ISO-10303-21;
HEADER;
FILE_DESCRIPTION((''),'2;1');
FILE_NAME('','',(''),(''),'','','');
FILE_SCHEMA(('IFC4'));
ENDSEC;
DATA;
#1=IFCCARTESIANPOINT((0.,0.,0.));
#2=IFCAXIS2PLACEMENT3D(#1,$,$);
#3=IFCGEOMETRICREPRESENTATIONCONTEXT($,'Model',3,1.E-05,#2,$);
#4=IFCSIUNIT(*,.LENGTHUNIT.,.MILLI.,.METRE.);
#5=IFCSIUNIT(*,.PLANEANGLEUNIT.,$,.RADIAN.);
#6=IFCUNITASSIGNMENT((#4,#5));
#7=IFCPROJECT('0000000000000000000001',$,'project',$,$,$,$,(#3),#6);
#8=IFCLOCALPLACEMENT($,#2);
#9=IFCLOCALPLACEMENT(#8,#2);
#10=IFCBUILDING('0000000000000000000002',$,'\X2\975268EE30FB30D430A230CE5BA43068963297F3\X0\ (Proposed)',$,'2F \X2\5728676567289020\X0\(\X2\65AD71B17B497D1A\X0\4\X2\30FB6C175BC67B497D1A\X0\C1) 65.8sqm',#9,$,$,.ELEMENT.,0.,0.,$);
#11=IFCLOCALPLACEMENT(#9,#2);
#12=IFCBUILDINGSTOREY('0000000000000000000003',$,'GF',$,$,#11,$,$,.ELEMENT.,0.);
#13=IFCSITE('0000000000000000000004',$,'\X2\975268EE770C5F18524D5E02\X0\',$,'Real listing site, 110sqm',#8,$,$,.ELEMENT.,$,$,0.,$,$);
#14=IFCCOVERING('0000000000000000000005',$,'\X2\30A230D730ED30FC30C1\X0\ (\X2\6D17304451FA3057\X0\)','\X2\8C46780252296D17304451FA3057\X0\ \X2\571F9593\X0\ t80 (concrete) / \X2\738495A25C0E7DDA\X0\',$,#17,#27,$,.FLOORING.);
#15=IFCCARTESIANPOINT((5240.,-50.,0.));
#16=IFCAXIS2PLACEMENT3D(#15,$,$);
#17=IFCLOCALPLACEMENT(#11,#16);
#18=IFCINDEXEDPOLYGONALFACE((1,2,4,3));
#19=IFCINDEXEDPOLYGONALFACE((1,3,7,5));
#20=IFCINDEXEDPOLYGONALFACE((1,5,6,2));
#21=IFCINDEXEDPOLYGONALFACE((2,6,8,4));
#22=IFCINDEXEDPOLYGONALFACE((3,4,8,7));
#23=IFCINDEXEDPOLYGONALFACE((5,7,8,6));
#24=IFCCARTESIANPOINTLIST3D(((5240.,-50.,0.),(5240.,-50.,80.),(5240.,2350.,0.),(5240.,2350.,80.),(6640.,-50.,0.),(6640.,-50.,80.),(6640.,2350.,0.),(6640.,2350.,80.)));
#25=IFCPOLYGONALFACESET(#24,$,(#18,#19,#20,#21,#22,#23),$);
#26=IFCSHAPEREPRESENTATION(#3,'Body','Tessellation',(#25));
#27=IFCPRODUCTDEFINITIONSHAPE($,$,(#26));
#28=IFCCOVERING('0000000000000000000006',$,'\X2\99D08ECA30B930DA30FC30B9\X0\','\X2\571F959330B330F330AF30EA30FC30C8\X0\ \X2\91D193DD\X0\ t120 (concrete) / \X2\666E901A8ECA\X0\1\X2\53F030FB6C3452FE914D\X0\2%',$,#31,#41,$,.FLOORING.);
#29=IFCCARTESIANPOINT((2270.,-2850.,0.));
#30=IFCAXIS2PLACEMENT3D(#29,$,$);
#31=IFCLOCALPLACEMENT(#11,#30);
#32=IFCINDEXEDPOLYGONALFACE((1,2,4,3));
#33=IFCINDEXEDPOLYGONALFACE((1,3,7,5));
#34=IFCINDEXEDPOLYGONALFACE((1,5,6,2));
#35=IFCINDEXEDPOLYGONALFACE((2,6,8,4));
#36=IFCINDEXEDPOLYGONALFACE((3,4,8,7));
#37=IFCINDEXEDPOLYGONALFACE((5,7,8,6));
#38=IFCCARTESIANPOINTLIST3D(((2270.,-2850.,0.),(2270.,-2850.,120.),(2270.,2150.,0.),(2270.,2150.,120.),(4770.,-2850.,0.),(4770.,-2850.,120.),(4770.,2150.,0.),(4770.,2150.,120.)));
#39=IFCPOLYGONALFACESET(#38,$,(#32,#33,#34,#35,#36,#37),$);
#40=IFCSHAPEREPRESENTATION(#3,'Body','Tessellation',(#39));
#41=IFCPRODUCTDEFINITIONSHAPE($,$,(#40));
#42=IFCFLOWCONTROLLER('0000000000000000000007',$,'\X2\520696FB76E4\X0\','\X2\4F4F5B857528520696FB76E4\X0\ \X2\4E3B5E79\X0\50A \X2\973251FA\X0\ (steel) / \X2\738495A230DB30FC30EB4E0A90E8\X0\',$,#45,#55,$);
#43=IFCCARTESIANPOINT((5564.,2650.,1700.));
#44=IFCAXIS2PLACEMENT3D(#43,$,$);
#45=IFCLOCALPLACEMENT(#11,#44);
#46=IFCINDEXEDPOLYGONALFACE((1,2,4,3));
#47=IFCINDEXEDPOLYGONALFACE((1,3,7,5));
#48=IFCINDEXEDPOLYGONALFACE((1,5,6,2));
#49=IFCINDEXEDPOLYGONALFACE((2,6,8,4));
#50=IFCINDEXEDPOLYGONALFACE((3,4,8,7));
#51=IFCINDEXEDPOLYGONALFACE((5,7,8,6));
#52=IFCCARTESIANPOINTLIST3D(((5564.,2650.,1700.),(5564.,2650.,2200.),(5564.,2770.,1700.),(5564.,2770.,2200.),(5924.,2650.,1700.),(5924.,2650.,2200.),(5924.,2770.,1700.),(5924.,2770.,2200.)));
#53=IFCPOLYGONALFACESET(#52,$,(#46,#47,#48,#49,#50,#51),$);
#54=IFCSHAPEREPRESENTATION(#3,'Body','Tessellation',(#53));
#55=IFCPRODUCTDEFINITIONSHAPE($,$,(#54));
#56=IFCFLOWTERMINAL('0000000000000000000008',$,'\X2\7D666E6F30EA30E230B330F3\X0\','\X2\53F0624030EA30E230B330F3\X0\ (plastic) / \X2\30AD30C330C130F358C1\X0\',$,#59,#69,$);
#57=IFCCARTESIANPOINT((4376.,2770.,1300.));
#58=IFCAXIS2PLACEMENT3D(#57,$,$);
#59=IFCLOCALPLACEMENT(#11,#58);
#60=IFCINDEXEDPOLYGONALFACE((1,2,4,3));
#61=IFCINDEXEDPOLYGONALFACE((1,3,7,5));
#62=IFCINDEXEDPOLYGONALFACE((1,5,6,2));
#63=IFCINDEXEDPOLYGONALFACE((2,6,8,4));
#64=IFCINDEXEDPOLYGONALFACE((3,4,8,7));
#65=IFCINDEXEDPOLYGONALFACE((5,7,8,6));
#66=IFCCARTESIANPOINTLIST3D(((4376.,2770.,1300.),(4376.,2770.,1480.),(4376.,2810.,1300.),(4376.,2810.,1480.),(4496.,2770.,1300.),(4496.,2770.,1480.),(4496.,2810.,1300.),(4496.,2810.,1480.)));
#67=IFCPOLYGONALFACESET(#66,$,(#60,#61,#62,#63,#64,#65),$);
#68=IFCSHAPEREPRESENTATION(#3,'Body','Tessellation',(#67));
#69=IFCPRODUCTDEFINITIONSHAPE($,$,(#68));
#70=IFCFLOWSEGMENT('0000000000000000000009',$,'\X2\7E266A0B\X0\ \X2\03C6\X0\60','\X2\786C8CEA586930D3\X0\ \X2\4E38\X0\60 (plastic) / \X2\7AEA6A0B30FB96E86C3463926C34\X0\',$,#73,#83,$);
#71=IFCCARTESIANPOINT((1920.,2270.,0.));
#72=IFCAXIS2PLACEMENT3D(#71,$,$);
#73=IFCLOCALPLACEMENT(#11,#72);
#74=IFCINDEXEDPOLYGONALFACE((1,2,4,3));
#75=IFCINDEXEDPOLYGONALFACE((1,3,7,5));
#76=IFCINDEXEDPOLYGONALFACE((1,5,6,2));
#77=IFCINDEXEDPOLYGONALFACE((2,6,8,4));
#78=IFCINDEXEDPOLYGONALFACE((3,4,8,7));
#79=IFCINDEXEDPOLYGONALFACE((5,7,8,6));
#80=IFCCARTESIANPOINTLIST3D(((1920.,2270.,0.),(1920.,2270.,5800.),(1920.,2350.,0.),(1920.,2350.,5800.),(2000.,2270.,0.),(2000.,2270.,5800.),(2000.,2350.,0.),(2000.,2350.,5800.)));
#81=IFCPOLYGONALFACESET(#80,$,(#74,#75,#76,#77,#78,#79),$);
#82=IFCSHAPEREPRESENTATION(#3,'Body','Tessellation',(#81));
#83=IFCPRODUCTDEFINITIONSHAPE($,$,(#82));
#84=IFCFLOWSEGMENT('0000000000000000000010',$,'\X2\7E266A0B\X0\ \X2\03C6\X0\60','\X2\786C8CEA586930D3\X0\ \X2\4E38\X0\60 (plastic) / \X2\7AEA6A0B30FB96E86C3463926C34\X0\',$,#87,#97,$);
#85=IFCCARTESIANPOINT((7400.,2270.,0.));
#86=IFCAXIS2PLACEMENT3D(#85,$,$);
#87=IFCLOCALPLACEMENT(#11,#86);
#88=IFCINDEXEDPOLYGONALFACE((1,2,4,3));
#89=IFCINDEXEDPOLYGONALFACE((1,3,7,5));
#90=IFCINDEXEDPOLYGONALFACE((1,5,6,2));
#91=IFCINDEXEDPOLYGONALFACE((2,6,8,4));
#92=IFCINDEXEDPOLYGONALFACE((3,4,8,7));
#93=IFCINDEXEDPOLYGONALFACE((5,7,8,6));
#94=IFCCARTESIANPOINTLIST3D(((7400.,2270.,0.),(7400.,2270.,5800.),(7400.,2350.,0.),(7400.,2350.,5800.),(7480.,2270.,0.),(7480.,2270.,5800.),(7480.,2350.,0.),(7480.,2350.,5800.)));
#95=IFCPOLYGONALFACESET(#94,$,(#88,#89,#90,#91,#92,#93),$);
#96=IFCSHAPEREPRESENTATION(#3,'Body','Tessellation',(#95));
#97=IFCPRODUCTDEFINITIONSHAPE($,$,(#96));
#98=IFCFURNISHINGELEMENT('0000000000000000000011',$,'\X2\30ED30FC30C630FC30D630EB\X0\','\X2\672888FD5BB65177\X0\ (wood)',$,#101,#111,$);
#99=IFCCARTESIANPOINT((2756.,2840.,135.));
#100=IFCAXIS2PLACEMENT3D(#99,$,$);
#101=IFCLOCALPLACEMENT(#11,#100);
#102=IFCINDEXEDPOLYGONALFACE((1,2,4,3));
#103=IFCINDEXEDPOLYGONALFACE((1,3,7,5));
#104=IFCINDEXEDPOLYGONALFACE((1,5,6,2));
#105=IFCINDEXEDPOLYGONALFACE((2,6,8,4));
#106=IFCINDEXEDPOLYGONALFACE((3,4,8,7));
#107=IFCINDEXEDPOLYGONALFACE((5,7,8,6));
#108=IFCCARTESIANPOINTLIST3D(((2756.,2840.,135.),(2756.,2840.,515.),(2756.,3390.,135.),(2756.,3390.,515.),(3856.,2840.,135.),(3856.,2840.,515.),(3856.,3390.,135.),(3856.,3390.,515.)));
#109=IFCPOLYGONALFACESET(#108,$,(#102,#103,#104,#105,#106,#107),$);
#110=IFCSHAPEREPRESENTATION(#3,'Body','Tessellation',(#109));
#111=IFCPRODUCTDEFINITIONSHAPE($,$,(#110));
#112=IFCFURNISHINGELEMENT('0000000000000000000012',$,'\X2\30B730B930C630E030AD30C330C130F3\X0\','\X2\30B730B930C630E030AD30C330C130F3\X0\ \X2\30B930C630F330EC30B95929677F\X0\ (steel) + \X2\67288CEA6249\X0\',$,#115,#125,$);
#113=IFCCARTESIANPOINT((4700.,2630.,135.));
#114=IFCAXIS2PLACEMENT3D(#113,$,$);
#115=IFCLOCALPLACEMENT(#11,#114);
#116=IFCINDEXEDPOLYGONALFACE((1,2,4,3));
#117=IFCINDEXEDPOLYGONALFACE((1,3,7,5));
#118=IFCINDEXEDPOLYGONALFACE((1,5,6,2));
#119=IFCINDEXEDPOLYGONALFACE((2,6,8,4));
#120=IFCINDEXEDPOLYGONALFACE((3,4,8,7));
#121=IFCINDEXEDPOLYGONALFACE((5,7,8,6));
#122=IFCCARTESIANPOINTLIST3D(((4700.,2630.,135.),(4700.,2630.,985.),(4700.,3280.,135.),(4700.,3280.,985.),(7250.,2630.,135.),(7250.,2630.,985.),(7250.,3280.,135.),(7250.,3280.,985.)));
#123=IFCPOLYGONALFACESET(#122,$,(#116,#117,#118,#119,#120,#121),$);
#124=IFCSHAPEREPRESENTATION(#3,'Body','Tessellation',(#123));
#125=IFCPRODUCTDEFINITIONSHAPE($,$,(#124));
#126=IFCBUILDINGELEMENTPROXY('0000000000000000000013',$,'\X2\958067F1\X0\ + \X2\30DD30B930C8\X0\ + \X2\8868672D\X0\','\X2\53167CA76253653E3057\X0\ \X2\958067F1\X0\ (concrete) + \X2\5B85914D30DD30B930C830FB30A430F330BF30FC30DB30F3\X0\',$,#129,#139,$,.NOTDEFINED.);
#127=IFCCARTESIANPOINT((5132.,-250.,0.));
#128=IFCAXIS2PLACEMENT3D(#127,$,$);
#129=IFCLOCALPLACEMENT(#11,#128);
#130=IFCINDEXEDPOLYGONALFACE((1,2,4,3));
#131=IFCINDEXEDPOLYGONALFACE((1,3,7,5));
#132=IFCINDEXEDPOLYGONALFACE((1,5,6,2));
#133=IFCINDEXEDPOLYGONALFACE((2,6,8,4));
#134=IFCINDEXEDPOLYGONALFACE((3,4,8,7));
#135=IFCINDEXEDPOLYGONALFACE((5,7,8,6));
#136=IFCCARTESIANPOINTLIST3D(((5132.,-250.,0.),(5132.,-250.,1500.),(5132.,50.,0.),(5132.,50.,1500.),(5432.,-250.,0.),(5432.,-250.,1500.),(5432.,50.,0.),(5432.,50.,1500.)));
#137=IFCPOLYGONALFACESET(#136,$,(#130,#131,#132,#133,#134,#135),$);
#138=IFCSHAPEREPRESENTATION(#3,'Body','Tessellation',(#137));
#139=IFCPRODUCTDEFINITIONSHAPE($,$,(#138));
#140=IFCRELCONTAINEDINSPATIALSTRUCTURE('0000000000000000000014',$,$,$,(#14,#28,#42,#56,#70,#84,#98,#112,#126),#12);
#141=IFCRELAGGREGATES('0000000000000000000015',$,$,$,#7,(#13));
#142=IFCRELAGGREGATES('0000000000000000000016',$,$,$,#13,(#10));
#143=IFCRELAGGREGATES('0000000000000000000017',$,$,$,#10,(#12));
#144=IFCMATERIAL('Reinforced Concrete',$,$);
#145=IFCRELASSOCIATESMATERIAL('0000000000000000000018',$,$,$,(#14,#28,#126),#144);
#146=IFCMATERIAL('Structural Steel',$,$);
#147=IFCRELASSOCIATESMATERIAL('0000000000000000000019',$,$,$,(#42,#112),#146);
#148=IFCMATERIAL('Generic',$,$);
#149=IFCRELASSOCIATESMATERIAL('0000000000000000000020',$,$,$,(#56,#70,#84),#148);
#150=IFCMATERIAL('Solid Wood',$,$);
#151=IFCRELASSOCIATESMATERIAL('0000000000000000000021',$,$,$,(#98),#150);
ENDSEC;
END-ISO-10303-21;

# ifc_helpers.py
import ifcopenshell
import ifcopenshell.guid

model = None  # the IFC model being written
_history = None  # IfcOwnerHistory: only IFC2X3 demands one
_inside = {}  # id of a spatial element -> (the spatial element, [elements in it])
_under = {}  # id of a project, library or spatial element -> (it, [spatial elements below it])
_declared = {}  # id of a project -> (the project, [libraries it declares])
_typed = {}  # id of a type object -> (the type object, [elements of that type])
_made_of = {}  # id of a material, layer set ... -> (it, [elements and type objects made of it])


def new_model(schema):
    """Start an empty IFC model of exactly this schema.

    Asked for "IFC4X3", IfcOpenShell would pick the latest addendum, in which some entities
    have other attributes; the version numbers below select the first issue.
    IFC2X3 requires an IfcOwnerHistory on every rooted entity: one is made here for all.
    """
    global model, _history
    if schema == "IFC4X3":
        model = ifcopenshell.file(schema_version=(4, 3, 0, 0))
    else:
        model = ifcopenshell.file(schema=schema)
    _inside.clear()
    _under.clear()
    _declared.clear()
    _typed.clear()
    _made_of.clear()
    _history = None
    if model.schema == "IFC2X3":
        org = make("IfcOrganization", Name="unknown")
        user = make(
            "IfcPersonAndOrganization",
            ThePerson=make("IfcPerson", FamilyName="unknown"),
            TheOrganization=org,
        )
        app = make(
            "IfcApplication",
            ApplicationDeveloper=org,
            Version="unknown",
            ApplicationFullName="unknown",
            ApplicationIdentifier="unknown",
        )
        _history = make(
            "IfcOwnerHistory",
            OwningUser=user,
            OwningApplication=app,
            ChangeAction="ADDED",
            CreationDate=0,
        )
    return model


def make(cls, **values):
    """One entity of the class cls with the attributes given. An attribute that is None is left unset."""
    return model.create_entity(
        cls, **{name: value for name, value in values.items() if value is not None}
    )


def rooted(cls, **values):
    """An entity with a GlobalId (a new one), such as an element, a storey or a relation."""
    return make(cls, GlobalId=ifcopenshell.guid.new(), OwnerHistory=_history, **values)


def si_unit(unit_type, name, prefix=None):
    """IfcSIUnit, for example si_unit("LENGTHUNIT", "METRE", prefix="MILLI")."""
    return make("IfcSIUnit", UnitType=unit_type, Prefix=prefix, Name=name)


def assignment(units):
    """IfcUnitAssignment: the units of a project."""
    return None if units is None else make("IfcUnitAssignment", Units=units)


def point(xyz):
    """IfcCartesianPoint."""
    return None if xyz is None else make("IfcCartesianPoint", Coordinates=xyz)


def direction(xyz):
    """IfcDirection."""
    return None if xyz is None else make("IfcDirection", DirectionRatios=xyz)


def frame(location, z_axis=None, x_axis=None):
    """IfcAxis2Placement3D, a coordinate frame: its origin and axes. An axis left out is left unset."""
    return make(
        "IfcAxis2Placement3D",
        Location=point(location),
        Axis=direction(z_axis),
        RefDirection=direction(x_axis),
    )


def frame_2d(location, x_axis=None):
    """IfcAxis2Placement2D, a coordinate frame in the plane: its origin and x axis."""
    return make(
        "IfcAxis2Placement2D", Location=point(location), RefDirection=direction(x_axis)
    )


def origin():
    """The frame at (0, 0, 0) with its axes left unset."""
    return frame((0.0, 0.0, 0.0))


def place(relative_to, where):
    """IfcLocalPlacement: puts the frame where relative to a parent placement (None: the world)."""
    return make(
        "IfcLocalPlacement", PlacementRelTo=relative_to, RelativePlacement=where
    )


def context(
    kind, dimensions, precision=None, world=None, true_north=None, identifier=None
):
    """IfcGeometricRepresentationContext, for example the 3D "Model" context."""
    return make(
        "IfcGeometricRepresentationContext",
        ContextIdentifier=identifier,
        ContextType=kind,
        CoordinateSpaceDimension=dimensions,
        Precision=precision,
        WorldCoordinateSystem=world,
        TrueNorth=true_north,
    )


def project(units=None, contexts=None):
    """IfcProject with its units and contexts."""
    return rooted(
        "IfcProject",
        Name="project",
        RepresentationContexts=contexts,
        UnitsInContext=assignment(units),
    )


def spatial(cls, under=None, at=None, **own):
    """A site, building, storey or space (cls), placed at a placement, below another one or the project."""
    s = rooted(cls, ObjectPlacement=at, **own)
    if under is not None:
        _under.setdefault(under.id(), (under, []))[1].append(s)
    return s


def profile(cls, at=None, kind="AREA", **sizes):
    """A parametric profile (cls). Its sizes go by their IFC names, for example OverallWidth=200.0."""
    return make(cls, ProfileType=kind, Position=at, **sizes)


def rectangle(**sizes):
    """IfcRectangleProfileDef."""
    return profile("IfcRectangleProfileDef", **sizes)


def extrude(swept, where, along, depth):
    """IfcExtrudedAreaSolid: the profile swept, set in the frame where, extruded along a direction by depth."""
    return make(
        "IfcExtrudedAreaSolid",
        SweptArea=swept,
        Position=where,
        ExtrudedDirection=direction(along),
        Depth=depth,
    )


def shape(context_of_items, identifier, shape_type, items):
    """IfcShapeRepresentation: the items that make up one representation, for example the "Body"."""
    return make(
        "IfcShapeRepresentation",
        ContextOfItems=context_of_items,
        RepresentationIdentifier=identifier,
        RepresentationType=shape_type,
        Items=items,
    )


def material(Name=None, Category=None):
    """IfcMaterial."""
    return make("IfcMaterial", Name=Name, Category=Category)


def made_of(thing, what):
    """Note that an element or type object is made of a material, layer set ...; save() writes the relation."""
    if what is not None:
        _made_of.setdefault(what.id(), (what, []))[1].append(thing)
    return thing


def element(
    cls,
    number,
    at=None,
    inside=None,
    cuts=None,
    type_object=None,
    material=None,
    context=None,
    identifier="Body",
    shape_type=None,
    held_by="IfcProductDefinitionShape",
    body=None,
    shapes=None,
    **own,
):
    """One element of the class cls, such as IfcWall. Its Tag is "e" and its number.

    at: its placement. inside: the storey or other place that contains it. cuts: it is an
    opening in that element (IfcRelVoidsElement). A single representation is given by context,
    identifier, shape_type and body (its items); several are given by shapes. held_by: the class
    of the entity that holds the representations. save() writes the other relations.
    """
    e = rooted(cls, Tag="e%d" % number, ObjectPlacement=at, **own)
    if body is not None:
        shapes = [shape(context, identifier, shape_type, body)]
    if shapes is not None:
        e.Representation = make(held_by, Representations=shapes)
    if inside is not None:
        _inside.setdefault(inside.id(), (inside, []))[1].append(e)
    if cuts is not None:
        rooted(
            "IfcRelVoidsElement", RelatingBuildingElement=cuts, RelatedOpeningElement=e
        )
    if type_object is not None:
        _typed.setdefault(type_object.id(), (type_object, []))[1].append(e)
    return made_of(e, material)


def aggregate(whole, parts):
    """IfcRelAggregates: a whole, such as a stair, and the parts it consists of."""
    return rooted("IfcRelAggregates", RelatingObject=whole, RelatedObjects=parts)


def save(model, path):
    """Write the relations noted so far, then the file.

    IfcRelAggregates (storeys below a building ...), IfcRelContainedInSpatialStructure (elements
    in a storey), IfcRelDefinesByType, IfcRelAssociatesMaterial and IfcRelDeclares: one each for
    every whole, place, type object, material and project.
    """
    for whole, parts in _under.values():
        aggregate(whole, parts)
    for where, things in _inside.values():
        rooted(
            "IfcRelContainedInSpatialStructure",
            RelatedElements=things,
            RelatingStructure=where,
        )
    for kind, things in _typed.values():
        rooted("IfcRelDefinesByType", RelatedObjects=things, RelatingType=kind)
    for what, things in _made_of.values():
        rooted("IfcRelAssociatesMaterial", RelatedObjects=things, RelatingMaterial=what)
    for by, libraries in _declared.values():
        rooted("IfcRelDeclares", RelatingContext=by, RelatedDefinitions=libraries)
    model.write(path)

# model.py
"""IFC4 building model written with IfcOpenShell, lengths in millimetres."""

from ifc_helpers import new_model, si_unit, frame, frame_2d, origin, place, context, project, spatial, rectangle, extrude, material, element, save


model = new_model("IFC4")

# Units and contexts
model_context = context("Model", 3, precision=1e-05, world=origin())
ifc_project = project(units=[si_unit("LENGTHUNIT", "METRE", prefix="MILLI"), si_unit("PLANEANGLEUNIT", "RADIAN")], contexts=[model_context])

# Site, building, storey
site_placement = place(None, origin())
site = spatial("IfcSite", under=ifc_project, at=site_placement, Name="青森県弘前市", ObjectType="Real listing site, 110sqm", CompositionType="ELEMENT", RefElevation=0.0)
building_placement = place(site_placement, origin())
building = spatial("IfcBuilding", under=site, at=building_placement, Name="青森・ピアノ室と防音 (Proposed)", ObjectType="2F 在来木造(断熱等級4・気密等級C1) 65.8sqm", CompositionType="ELEMENT", ElevationOfRefHeight=0.0, ElevationOfTerrain=0.0)
storey_placement = place(building_placement, origin())
storey = spatial("IfcBuildingStorey", under=building, at=storey_placement, Name="GF", CompositionType="ELEMENT", Elevation=0.0)

# Shared definitions
ifc_material_1 = material(Name="Solid Wood")

# Shared definitions
ifc_material_2 = material(Name="Reinforced Concrete")

# Coverings
ifc_material_3 = material(Name="Generic")
covering_1_placement = place(storey_placement, frame((5240.0, -50.0, 0.0)))
element("IfcCovering", 1, at=covering_1_placement, inside=storey, material=ifc_material_2, Name="アプローチ (洗い出し)", Description="豆砂利洗い出し 土間 t80 (concrete) / 玄関導線", PredefinedType="FLOORING", context=model_context, shape_type="SweptSolid", body=[
    extrude(rectangle(XDim=1400.0, YDim=2400.0, at=frame_2d((700.0, 1200.0))), frame((5240.0, -50.0, 0.0)), (0.0, 0.0, 1.0), 80.0),
])
covering_2_placement = place(storey_placement, frame((2270.0, -2850.0, 0.0)))
element("IfcCovering", 2, at=covering_2_placement, inside=storey, material=ifc_material_2, Name="駐車スペース", Description="土間コンクリート 金鏝 t120 (concrete) / 普通車1台・水勾配2%", PredefinedType="FLOORING", context=model_context, shape_type="SweptSolid", body=[
    extrude(rectangle(XDim=2500.0, YDim=5000.0, at=frame_2d((1250.0, 2500.0))), frame((2270.0, -2850.0, 0.0)), (0.0, 0.0, 1.0), 120.0),
])

# Flow controller
ifc_material_4 = material(Name="Structural Steel")
flow_controller_placement = place(storey_placement, frame((5564.0, 2650.0, 1700.0)))
element("IfcFlowController", 3, at=flow_controller_placement, inside=storey, material=ifc_material_4, Name="分電盤", Description="住宅用分電盤 主幹50A 露出 (steel) / 玄関ホール上部", context=model_context, shape_type="SweptSolid", body=[
    extrude(rectangle(XDim=360.0, YDim=120.0, at=frame_2d((180.0, 60.0))), frame((5564.0, 2650.0, 1700.0)), (0.0, 0.0, 1.0), 500.0),
])

# Flow terminal
flow_terminal_placement = place(storey_placement, frame((4376.0, 2770.0, 1300.0)))
element("IfcFlowTerminal", 4, at=flow_terminal_placement, inside=storey, material=ifc_material_3, Name="給湯リモコン", Description="台所リモコン (plastic) / キッチン壁", context=model_context, shape_type="SweptSolid", body=[
    extrude(rectangle(XDim=120.0, YDim=40.0, at=frame_2d((60.0, 20.0))), frame((4376.0, 2770.0, 1300.0)), (0.0, 0.0, 1.0), 180.0),
])

# Flow segments
flow_segment_1_placement = place(storey_placement, frame((1920.0, 2270.0, 0.0)))
element("IfcFlowSegment", 5, at=flow_segment_1_placement, inside=storey, material=ifc_material_3, Name="縦樋 φ60", Description="硬質塩ビ 丸60 (plastic) / 竪樋・雨水排水", context=model_context, shape_type="SweptSolid", body=[
    extrude(rectangle(XDim=80.0, YDim=80.0, at=frame_2d((40.0, 40.0))), frame((1920.0, 2270.0, 0.0)), (0.0, 0.0, 1.0), 5800.0),
])
flow_segment_2_placement = place(storey_placement, frame((7400.0, 2270.0, 0.0)))
element("IfcFlowSegment", 6, at=flow_segment_2_placement, inside=storey, material=ifc_material_3, Name="縦樋 φ60", Description="硬質塩ビ 丸60 (plastic) / 竪樋・雨水排水", context=model_context, shape_type="SweptSolid", body=[
    extrude(rectangle(XDim=80.0, YDim=80.0, at=frame_2d((40.0, 40.0))), frame((7400.0, 2270.0, 0.0)), (0.0, 0.0, 1.0), 5800.0),
])

# Furnishing elements
furnishing_1_placement = place(storey_placement, frame((2756.0, 2840.0, 135.0)))
element("IfcFurnishingElement", 7, at=furnishing_1_placement, inside=storey, material=ifc_material_1, Name="ローテーブル", Description="木製家具 (wood)", context=model_context, shape_type="SweptSolid", body=[
    extrude(rectangle(XDim=1100.0, YDim=550.0, at=frame_2d((550.0, 275.0))), frame((2756.0, 2840.0, 135.0)), (0.0, 0.0, 1.0), 380.0),
])
furnishing_2_placement = place(storey_placement, frame((4700.0, 2630.0, 135.0)))
element("IfcFurnishingElement", 8, at=furnishing_2_placement, inside=storey, material=ifc_material_4, Name="システムキッチン", Description="システムキッチン ステンレス天板 (steel) + 木質扉", context=model_context, shape_type="SweptSolid", body=[
    extrude(rectangle(XDim=2550.0, YDim=650.0, at=frame_2d((1275.0, 325.0))), frame((4700.0, 2630.0, 135.0)), (0.0, 0.0, 1.0), 850.0),
])

# Building element proxy
proxy_placement = place(storey_placement, frame((5132.0, -250.0, 0.0)))
element("IfcBuildingElementProxy", 9, at=proxy_placement, inside=storey, material=ifc_material_2, Name="門柱 + ポスト + 表札", Description="化粧打放し 門柱 (concrete) + 宅配ポスト・インターホン", PredefinedType="NOTDEFINED", context=model_context, shape_type="SweptSolid", body=[
    extrude(rectangle(XDim=300.0, YDim=300.0, at=frame_2d((150.0, 150.0))), frame((5132.0, -250.0, 0.0)), (0.0, 0.0, 1.0), 1500.0),
])

save(model, "model.ifc")
